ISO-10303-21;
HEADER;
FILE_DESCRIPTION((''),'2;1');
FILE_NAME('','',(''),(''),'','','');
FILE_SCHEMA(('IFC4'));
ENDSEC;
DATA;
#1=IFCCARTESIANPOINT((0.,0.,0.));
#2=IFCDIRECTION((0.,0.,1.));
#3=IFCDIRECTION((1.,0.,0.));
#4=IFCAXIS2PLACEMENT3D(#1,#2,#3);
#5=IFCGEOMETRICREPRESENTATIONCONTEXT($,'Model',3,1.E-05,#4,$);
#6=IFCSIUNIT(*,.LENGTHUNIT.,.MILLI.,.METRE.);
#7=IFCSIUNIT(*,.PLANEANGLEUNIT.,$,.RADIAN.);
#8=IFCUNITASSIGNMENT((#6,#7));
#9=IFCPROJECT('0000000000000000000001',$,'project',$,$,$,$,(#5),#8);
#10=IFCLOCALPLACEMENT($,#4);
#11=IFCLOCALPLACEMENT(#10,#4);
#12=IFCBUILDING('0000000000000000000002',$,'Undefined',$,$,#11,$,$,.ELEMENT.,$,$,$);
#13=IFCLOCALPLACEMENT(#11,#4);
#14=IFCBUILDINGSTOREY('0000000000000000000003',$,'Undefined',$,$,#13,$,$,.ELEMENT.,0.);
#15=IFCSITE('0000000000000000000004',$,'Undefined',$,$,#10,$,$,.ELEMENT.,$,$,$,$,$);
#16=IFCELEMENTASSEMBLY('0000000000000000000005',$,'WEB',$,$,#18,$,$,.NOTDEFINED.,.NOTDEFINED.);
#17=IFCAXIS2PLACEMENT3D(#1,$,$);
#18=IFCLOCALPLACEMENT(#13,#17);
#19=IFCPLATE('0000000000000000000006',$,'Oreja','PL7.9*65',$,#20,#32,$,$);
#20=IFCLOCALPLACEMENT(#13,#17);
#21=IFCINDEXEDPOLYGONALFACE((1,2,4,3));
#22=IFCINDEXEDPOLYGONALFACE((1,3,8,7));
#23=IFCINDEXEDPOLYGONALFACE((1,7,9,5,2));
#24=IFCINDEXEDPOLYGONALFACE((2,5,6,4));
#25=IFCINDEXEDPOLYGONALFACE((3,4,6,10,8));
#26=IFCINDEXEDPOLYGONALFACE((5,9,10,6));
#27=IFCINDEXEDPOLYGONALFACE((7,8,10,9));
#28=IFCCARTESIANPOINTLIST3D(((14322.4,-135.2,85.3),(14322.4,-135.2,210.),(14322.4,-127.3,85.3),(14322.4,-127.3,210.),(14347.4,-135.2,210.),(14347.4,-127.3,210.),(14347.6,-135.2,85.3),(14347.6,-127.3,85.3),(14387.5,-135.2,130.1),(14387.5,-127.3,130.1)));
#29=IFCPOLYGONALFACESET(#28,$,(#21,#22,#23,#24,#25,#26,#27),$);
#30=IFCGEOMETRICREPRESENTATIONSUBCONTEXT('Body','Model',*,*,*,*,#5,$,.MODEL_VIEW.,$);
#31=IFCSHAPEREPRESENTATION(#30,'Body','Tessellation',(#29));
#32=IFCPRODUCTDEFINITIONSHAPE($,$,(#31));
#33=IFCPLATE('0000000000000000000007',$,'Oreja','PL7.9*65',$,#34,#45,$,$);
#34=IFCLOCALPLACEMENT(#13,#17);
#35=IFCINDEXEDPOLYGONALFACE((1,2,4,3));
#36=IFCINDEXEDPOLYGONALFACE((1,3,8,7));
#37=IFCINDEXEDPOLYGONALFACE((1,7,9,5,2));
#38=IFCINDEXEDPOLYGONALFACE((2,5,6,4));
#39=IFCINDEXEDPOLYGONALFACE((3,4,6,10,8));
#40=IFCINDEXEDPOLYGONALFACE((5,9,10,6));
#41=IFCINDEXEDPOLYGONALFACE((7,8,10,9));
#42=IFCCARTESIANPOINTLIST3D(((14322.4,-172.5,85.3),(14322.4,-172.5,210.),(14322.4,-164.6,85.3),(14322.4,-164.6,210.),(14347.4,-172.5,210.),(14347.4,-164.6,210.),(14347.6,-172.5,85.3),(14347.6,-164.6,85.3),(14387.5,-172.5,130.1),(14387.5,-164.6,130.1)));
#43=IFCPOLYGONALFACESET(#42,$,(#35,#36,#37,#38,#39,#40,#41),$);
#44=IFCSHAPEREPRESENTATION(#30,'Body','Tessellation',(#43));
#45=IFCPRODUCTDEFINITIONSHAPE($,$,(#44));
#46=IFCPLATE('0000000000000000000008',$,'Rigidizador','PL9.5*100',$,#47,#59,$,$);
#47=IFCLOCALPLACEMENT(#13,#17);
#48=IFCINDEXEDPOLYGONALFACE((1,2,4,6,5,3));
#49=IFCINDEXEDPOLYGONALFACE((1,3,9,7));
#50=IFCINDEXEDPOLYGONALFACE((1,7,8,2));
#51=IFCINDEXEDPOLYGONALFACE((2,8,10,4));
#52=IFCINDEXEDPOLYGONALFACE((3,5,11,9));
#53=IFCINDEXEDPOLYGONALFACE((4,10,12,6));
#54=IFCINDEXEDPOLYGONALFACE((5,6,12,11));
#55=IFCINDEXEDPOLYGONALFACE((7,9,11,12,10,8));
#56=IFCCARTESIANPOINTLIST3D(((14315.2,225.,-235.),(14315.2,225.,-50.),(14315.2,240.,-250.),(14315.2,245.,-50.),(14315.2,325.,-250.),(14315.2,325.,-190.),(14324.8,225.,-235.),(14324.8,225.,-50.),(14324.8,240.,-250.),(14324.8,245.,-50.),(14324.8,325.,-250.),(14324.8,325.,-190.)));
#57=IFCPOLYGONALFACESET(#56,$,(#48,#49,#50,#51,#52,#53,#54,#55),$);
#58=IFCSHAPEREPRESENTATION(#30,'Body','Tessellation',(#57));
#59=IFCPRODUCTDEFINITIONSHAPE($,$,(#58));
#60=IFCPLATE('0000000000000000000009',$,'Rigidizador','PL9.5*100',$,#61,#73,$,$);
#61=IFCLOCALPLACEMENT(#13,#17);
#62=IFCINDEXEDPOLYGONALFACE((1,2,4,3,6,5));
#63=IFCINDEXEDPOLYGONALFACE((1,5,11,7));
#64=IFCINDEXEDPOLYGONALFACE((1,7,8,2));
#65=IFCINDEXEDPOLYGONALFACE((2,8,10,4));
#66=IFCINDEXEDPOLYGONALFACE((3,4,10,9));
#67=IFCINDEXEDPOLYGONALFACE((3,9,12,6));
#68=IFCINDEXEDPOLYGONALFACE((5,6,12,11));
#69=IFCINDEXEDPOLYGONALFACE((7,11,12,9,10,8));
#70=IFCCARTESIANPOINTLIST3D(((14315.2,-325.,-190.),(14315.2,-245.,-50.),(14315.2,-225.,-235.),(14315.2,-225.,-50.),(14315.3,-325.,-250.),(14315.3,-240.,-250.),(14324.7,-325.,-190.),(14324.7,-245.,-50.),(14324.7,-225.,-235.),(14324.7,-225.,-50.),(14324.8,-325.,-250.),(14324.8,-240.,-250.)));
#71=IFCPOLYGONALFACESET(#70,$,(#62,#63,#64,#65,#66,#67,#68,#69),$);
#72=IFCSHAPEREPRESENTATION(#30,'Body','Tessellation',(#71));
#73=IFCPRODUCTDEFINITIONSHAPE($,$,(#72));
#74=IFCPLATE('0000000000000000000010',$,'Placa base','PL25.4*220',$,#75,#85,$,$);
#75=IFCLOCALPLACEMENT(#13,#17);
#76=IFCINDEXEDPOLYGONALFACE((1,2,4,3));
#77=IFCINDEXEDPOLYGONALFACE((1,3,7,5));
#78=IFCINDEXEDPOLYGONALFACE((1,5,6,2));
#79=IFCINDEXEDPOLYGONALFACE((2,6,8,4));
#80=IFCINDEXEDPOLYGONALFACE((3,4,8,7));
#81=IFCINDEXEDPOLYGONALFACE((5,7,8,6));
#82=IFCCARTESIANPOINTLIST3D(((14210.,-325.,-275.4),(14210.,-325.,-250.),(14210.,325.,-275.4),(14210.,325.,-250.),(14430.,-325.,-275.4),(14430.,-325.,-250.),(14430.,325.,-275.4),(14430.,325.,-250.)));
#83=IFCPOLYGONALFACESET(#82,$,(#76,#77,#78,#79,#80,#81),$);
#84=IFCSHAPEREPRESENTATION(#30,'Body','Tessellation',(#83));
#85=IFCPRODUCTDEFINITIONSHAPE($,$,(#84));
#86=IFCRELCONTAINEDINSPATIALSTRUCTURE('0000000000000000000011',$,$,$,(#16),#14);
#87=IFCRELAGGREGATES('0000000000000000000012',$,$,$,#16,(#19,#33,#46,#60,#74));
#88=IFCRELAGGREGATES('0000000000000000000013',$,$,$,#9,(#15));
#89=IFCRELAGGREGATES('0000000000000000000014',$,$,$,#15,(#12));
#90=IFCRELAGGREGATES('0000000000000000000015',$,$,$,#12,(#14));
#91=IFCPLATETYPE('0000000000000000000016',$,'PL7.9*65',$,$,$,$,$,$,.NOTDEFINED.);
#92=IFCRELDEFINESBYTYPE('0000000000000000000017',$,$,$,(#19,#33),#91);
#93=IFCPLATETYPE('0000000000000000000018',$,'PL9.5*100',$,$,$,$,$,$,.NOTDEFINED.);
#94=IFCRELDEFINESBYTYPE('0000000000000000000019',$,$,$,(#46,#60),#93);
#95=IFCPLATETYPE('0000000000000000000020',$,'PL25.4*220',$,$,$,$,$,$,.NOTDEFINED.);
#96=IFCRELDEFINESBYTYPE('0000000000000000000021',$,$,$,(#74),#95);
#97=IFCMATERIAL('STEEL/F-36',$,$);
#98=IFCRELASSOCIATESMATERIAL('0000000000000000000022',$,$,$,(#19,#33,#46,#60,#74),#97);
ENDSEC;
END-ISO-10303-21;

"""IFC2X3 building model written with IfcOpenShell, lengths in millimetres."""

from ifc_helpers import new_model, si_unit, frame, origin_with_axes, place, context, subcontext, project, spatial, polyline, outline, extrude, material, type_object, element, aggregate, save


model = new_model("IFC2X3")

# Units and contexts
model_context = context("Model", 3, precision=1e-05, world=origin_with_axes())
body_context = subcontext(model_context, "Body", "Model", "MODEL_VIEW")
ifc_project = project(units=[si_unit("LENGTHUNIT", "METRE", prefix="MILLI"), si_unit("PLANEANGLEUNIT", "RADIAN")], contexts=[model_context])

# Site, building, storey
site_placement = place(None, origin_with_axes())
site = spatial("IfcSite", under=ifc_project, at=site_placement, Name="Undefined", CompositionType="ELEMENT")
building_placement = place(site_placement, origin_with_axes())
building = spatial("IfcBuilding", under=site, at=building_placement, Name="Undefined", CompositionType="ELEMENT")
storey_placement = place(building_placement, origin_with_axes())
storey = spatial("IfcBuildingStorey", under=building, at=storey_placement, Name="Undefined", CompositionType="ELEMENT", Elevation=0.0)

# Element assembly, plates
assembly_1_placement = place(storey_placement, origin_with_axes())
assembly_1 = element("IfcElementAssembly", 1, at=assembly_1_placement, inside=storey, Name="WEB", AssemblyPlace="NOTDEFINED", PredefinedType="NOTDEFINED")
ifc_material_1 = material(Name="STEEL/F-36")
plate_type_1 = type_object("IfcPlateType", Name="PL7.9*65", PredefinedType="NOTDEFINED")
plate_1_placement = place(assembly_1_placement, frame((14322.4, -131.3, 210.0), z_axis=(0.0, -1.0, 0.000005), x_axis=(0.0, -0.000005, -1.0)))
plate_1 = element("IfcPlate", 2, at=plate_1_placement, type_object=plate_type_1, material=ifc_material_1, Name="Oreja", Description="PL7.9*65", context=body_context, shape_type="SweptSolid", body=[
    extrude(outline(polyline([(0.0, 0.0), (124.7, 0.0), (124.7, 25.2), (79.9, 65.1), (0.0, 25.0), (0.0, 0.0)])), frame((0.0, 0.0, -4.0), z_axis=(0.0, 0.0, 1.0), x_axis=(1.0, 0.0, 0.0)), (0.0, 0.0, 1.0), 7.9),
])
plate_2_placement = place(assembly_1_placement, frame((14322.4, -168.6, 210.0), z_axis=(0.0, -1.0, -0.000006), x_axis=(0.0, 0.000007, -1.0)))
plate_2 = element("IfcPlate", 3, at=plate_2_placement, type_object=plate_type_1, material=ifc_material_1, Name="Oreja", Description="PL7.9*65", context=body_context, shape_type="SweptSolid", body=[
    extrude(outline(polyline([(0.0, 0.0), (124.7, 0.0), (124.7, 25.2), (79.9, 65.1), (0.0, 25.0), (0.0, 0.0)])), frame((0.0, 0.0, -4.0), z_axis=(0.0, 0.0, 1.0), x_axis=(1.0, 0.0, 0.0)), (0.0, 0.0, 1.0), 7.9),
])
plate_type_2 = type_object("IfcPlateType", Name="PL9.5*100", PredefinedType="NOTDEFINED")
plate_3_placement = place(assembly_1_placement, frame((14320.0, 225.0, -250.0), z_axis=(1.0, 0.0, 0.0), x_axis=(0.0, 1.0, 0.0)))
plate_3 = element("IfcPlate", 4, at=plate_3_placement, type_object=plate_type_2, material=ifc_material_1, Name="Rigidizador", Description="PL9.5*100", context=body_context, shape_type="SweptSolid", body=[
    extrude(outline(polyline([(0.0, 15.0), (15.0, 0.0), (100.0, 0.0), (100.0, 60.0), (20.0, 200.0), (0.0, 200.0), (0.0, 15.0)])), frame((0.0, 0.0, -4.7), z_axis=(0.0, 0.0, 1.0), x_axis=(1.0, 0.0, 0.0)), (0.0, 0.0, 1.0), 9.5),
])
plate_4_placement = place(assembly_1_placement, frame((14320.0, -225.0, -250.0), z_axis=(-1.0, 0.0, 0.0), x_axis=(0.0, -1.0, 0.0)))
plate_4 = element("IfcPlate", 5, at=plate_4_placement, type_object=plate_type_2, material=ifc_material_1, Name="Rigidizador", Description="PL9.5*100", context=body_context, shape_type="SweptSolid", body=[
    extrude(outline(polyline([(0.0, 15.0), (15.0, 0.0), (100.0, 0.0), (100.0, 60.0), (20.0, 200.0), (0.0, 200.0), (0.0, 15.0)])), frame((0.0, 0.0, -4.7), z_axis=(0.0, 0.0, 1.0), x_axis=(1.0, 0.0, 0.0)), (0.0, 0.0, 1.0), 9.5),
])
plate_type_3 = type_object("IfcPlateType", Name="PL25.4*220", PredefinedType="NOTDEFINED")
plate_5_placement = place(assembly_1_placement, frame((14430.0, 325.0, -262.7), z_axis=(0.0, 0.0, 1.0), x_axis=(-1.0, 0.0, 0.0)))
plate_5 = element("IfcPlate", 6, at=plate_5_placement, type_object=plate_type_3, material=ifc_material_1, Name="Placa base", Description="PL25.4*220", context=body_context, shape_type="SweptSolid", body=[
    extrude(outline(polyline([(0.0, 0.0), (220.0, 0.0), (220.0, 650.0), (0.0, 650.0), (0.0, 0.0)])), frame((0.0, 0.0, -12.7), z_axis=(0.0, 0.0, 1.0), x_axis=(1.0, 0.0, 0.0)), (0.0, 0.0, 1.0), 25.4),
])

aggregate(assembly_1, [plate_1, plate_2, plate_3, plate_4, plate_5])

save(model, "model.ifc")
